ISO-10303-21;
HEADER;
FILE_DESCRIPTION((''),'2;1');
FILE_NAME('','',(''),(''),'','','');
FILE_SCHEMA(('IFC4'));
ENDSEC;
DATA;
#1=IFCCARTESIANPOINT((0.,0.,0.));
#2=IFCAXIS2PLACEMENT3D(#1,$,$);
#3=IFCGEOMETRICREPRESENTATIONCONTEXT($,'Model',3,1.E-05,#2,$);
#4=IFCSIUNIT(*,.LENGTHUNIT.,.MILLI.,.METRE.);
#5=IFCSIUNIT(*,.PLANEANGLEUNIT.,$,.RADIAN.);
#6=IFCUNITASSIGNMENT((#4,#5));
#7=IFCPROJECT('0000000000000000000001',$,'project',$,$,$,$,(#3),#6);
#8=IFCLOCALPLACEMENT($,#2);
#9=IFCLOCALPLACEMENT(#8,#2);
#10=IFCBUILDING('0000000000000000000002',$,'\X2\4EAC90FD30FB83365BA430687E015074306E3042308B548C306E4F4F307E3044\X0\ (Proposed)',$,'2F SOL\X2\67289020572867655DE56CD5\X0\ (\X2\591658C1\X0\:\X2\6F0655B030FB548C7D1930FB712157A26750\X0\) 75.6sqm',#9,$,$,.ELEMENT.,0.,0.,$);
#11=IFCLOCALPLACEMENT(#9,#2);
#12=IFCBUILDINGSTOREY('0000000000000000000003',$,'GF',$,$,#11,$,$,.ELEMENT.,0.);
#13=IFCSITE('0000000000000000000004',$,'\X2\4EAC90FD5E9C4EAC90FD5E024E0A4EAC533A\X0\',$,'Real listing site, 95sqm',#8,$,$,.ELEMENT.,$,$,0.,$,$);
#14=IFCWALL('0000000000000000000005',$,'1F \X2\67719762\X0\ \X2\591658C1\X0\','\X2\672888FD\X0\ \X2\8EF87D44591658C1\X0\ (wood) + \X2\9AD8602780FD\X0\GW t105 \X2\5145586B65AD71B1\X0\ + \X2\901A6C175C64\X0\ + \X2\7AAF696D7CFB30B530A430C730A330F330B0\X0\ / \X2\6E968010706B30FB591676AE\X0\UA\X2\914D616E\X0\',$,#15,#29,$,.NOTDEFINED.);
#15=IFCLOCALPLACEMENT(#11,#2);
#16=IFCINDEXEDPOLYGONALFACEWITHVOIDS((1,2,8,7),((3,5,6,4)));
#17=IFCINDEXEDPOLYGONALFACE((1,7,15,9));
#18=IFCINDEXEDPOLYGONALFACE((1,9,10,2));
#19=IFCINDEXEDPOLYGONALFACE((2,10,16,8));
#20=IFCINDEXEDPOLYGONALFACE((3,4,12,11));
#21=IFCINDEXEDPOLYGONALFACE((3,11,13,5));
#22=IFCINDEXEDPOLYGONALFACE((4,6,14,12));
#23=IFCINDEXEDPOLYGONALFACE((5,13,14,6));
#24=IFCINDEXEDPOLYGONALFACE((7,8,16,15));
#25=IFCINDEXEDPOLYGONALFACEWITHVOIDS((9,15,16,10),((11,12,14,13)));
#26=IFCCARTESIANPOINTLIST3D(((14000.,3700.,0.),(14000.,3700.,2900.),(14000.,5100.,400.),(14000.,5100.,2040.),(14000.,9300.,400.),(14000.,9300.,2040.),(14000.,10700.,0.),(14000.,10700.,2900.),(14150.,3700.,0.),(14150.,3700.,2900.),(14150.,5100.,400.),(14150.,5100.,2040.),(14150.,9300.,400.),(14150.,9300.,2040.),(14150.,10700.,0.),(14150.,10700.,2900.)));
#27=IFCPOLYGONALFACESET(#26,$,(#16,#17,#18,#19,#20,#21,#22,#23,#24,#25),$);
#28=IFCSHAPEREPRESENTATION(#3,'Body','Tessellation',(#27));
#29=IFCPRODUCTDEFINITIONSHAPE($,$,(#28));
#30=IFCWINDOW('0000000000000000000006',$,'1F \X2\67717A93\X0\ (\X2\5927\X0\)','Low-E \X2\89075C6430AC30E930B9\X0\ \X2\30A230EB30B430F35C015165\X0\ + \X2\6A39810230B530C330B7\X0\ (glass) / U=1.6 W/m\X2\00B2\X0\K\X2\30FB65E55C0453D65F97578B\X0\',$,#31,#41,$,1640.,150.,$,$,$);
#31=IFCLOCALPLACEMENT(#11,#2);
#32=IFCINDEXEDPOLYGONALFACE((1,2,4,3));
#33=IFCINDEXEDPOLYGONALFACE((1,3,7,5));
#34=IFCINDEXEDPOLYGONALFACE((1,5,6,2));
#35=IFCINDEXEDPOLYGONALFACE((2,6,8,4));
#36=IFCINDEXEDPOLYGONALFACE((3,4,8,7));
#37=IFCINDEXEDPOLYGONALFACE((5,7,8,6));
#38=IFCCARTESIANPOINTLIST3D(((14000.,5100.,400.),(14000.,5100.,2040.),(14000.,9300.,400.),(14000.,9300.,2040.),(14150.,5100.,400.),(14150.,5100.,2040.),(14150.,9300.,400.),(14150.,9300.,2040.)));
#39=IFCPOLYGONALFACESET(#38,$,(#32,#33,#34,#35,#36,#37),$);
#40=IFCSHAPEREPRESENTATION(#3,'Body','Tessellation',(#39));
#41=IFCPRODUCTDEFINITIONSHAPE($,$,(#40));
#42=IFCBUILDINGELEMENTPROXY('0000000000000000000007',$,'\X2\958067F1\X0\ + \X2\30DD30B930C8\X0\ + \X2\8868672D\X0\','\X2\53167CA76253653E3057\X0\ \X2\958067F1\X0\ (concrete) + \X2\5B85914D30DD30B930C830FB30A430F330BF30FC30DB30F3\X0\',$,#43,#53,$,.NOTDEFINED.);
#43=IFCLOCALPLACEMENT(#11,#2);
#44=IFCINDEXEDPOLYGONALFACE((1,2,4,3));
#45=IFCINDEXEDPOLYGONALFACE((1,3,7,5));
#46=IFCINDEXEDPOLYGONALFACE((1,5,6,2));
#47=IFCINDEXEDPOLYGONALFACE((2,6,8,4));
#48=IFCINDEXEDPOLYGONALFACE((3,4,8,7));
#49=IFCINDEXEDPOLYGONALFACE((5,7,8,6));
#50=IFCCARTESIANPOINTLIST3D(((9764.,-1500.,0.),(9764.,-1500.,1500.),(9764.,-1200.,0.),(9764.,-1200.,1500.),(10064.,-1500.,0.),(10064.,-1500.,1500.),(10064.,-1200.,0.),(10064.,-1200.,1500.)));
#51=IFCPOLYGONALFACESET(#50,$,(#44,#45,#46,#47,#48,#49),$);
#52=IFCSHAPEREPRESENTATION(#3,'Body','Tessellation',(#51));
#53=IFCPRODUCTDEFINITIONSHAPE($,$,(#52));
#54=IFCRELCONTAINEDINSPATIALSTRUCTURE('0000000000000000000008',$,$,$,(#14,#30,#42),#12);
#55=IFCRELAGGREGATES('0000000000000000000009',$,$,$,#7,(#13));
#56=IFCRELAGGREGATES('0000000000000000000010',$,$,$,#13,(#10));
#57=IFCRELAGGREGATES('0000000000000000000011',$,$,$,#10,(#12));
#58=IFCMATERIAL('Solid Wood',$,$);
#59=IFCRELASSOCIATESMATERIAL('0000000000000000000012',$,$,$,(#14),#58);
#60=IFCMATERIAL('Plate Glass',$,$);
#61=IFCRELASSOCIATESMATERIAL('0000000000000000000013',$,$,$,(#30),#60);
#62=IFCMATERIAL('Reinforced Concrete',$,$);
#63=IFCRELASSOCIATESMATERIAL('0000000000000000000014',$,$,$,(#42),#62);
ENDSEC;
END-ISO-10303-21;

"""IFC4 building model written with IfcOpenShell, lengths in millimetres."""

from ifc_helpers import new_model, si_unit, frame, frame_2d, origin, place, context, project, spatial, rectangle, extrude, material, element, fill, save


model = new_model("IFC4")

# Units and contexts
model_context = context("Model", 3, precision=1e-05, world=origin())
ifc_project = project(units=[si_unit("LENGTHUNIT", "METRE", prefix="MILLI"), si_unit("PLANEANGLEUNIT", "RADIAN")], contexts=[model_context])

# Site, building, storey
site_placement = place(None, origin())
site = spatial("IfcSite", under=ifc_project, at=site_placement, Name="京都府京都市上京区", ObjectType="Real listing site, 95sqm", CompositionType="ELEMENT", RefElevation=0.0)
building_placement = place(site_placement, origin())
building = spatial("IfcBuilding", under=site, at=building_placement, Name="京都・茶室と縁側のある和の住まい (Proposed)", ObjectType="2F SOL木造在来工法 (外壁:漆喰・和紙・無垢材) 75.6sqm", CompositionType="ELEMENT", ElevationOfRefHeight=0.0, ElevationOfTerrain=0.0)
storey_placement = place(building_placement, origin())
storey = spatial("IfcBuildingStorey", under=building, at=storey_placement, Name="GF", CompositionType="ELEMENT", Elevation=0.0)

# Shared definitions
ifc_material_1 = material(Name="Solid Wood")

# Wall, opening, window
wall_1_placement = place(storey_placement, frame((7000.0, 1850.0, 0.0)))
wall_1 = element("IfcWall", 1, at=wall_1_placement, inside=storey, material=ifc_material_1, Name="1F 東面 外壁", Description="木製 軸組外壁 (wood) + 高性能GW t105 充填断熱 + 通気層 + 窯業系サイディング / 準耐火・外皮UA配慮", PredefinedType="NOTDEFINED", context=model_context, shape_type="SweptSolid", body=[
    extrude(rectangle(XDim=150.0, YDim=7000.0, at=frame_2d((75.0, 3500.0))), frame((7000.0, 1850.0, 0.0)), (0.0, 0.0, 1.0), 2900.0),
])
opening_1_placement = place(storey_placement, frame((7000.0, 2550.0, 200.0)))
opening_1 = element("IfcOpeningElement", 2, at=opening_1_placement, cuts=wall_1, PredefinedType="NOTDEFINED", context=model_context, shape_type="SweptSolid", body=[
    extrude(rectangle(XDim=150.0, YDim=4200.0, at=frame_2d((75.0, 2100.0))), frame((7000.0, 2550.0, 200.0)), (0.0, 0.0, 1.0), 1640.0),
])
ifc_material_2 = material(Name="Plate Glass")
window_1_placement = place(storey_placement, frame((7000.0, 2550.0, 200.0)))
window_1 = element("IfcWindow", 3, at=window_1_placement, inside=storey, material=ifc_material_2, Name="1F 東窓 (大)", Description="Low-E 複層ガラス アルゴン封入 + 樹脂サッシ (glass) / U=1.6 W/m²K・日射取得型", OverallHeight=1640.0, OverallWidth=150.0, context=model_context, shape_type="SweptSolid", body=[
    extrude(rectangle(XDim=150.0, YDim=4200.0, at=frame_2d((75.0, 2100.0))), frame((7000.0, 2550.0, 200.0)), (0.0, 0.0, 1.0), 1640.0),
])
fill(opening_1, window_1)

# Shared definitions
ifc_material_3 = material(Name="Reinforced Concrete")

# Building element proxy
proxy_placement = place(storey_placement, frame((4882.0, -750.0, 0.0)))
element("IfcBuildingElementProxy", 4, at=proxy_placement, inside=storey, material=ifc_material_3, Name="門柱 + ポスト + 表札", Description="化粧打放し 門柱 (concrete) + 宅配ポスト・インターホン", PredefinedType="NOTDEFINED", context=model_context, shape_type="SweptSolid", body=[
    extrude(rectangle(XDim=300.0, YDim=300.0, at=frame_2d((150.0, 150.0))), frame((4882.0, -750.0, 0.0)), (0.0, 0.0, 1.0), 1500.0),
])

save(model, "model.ifc")
